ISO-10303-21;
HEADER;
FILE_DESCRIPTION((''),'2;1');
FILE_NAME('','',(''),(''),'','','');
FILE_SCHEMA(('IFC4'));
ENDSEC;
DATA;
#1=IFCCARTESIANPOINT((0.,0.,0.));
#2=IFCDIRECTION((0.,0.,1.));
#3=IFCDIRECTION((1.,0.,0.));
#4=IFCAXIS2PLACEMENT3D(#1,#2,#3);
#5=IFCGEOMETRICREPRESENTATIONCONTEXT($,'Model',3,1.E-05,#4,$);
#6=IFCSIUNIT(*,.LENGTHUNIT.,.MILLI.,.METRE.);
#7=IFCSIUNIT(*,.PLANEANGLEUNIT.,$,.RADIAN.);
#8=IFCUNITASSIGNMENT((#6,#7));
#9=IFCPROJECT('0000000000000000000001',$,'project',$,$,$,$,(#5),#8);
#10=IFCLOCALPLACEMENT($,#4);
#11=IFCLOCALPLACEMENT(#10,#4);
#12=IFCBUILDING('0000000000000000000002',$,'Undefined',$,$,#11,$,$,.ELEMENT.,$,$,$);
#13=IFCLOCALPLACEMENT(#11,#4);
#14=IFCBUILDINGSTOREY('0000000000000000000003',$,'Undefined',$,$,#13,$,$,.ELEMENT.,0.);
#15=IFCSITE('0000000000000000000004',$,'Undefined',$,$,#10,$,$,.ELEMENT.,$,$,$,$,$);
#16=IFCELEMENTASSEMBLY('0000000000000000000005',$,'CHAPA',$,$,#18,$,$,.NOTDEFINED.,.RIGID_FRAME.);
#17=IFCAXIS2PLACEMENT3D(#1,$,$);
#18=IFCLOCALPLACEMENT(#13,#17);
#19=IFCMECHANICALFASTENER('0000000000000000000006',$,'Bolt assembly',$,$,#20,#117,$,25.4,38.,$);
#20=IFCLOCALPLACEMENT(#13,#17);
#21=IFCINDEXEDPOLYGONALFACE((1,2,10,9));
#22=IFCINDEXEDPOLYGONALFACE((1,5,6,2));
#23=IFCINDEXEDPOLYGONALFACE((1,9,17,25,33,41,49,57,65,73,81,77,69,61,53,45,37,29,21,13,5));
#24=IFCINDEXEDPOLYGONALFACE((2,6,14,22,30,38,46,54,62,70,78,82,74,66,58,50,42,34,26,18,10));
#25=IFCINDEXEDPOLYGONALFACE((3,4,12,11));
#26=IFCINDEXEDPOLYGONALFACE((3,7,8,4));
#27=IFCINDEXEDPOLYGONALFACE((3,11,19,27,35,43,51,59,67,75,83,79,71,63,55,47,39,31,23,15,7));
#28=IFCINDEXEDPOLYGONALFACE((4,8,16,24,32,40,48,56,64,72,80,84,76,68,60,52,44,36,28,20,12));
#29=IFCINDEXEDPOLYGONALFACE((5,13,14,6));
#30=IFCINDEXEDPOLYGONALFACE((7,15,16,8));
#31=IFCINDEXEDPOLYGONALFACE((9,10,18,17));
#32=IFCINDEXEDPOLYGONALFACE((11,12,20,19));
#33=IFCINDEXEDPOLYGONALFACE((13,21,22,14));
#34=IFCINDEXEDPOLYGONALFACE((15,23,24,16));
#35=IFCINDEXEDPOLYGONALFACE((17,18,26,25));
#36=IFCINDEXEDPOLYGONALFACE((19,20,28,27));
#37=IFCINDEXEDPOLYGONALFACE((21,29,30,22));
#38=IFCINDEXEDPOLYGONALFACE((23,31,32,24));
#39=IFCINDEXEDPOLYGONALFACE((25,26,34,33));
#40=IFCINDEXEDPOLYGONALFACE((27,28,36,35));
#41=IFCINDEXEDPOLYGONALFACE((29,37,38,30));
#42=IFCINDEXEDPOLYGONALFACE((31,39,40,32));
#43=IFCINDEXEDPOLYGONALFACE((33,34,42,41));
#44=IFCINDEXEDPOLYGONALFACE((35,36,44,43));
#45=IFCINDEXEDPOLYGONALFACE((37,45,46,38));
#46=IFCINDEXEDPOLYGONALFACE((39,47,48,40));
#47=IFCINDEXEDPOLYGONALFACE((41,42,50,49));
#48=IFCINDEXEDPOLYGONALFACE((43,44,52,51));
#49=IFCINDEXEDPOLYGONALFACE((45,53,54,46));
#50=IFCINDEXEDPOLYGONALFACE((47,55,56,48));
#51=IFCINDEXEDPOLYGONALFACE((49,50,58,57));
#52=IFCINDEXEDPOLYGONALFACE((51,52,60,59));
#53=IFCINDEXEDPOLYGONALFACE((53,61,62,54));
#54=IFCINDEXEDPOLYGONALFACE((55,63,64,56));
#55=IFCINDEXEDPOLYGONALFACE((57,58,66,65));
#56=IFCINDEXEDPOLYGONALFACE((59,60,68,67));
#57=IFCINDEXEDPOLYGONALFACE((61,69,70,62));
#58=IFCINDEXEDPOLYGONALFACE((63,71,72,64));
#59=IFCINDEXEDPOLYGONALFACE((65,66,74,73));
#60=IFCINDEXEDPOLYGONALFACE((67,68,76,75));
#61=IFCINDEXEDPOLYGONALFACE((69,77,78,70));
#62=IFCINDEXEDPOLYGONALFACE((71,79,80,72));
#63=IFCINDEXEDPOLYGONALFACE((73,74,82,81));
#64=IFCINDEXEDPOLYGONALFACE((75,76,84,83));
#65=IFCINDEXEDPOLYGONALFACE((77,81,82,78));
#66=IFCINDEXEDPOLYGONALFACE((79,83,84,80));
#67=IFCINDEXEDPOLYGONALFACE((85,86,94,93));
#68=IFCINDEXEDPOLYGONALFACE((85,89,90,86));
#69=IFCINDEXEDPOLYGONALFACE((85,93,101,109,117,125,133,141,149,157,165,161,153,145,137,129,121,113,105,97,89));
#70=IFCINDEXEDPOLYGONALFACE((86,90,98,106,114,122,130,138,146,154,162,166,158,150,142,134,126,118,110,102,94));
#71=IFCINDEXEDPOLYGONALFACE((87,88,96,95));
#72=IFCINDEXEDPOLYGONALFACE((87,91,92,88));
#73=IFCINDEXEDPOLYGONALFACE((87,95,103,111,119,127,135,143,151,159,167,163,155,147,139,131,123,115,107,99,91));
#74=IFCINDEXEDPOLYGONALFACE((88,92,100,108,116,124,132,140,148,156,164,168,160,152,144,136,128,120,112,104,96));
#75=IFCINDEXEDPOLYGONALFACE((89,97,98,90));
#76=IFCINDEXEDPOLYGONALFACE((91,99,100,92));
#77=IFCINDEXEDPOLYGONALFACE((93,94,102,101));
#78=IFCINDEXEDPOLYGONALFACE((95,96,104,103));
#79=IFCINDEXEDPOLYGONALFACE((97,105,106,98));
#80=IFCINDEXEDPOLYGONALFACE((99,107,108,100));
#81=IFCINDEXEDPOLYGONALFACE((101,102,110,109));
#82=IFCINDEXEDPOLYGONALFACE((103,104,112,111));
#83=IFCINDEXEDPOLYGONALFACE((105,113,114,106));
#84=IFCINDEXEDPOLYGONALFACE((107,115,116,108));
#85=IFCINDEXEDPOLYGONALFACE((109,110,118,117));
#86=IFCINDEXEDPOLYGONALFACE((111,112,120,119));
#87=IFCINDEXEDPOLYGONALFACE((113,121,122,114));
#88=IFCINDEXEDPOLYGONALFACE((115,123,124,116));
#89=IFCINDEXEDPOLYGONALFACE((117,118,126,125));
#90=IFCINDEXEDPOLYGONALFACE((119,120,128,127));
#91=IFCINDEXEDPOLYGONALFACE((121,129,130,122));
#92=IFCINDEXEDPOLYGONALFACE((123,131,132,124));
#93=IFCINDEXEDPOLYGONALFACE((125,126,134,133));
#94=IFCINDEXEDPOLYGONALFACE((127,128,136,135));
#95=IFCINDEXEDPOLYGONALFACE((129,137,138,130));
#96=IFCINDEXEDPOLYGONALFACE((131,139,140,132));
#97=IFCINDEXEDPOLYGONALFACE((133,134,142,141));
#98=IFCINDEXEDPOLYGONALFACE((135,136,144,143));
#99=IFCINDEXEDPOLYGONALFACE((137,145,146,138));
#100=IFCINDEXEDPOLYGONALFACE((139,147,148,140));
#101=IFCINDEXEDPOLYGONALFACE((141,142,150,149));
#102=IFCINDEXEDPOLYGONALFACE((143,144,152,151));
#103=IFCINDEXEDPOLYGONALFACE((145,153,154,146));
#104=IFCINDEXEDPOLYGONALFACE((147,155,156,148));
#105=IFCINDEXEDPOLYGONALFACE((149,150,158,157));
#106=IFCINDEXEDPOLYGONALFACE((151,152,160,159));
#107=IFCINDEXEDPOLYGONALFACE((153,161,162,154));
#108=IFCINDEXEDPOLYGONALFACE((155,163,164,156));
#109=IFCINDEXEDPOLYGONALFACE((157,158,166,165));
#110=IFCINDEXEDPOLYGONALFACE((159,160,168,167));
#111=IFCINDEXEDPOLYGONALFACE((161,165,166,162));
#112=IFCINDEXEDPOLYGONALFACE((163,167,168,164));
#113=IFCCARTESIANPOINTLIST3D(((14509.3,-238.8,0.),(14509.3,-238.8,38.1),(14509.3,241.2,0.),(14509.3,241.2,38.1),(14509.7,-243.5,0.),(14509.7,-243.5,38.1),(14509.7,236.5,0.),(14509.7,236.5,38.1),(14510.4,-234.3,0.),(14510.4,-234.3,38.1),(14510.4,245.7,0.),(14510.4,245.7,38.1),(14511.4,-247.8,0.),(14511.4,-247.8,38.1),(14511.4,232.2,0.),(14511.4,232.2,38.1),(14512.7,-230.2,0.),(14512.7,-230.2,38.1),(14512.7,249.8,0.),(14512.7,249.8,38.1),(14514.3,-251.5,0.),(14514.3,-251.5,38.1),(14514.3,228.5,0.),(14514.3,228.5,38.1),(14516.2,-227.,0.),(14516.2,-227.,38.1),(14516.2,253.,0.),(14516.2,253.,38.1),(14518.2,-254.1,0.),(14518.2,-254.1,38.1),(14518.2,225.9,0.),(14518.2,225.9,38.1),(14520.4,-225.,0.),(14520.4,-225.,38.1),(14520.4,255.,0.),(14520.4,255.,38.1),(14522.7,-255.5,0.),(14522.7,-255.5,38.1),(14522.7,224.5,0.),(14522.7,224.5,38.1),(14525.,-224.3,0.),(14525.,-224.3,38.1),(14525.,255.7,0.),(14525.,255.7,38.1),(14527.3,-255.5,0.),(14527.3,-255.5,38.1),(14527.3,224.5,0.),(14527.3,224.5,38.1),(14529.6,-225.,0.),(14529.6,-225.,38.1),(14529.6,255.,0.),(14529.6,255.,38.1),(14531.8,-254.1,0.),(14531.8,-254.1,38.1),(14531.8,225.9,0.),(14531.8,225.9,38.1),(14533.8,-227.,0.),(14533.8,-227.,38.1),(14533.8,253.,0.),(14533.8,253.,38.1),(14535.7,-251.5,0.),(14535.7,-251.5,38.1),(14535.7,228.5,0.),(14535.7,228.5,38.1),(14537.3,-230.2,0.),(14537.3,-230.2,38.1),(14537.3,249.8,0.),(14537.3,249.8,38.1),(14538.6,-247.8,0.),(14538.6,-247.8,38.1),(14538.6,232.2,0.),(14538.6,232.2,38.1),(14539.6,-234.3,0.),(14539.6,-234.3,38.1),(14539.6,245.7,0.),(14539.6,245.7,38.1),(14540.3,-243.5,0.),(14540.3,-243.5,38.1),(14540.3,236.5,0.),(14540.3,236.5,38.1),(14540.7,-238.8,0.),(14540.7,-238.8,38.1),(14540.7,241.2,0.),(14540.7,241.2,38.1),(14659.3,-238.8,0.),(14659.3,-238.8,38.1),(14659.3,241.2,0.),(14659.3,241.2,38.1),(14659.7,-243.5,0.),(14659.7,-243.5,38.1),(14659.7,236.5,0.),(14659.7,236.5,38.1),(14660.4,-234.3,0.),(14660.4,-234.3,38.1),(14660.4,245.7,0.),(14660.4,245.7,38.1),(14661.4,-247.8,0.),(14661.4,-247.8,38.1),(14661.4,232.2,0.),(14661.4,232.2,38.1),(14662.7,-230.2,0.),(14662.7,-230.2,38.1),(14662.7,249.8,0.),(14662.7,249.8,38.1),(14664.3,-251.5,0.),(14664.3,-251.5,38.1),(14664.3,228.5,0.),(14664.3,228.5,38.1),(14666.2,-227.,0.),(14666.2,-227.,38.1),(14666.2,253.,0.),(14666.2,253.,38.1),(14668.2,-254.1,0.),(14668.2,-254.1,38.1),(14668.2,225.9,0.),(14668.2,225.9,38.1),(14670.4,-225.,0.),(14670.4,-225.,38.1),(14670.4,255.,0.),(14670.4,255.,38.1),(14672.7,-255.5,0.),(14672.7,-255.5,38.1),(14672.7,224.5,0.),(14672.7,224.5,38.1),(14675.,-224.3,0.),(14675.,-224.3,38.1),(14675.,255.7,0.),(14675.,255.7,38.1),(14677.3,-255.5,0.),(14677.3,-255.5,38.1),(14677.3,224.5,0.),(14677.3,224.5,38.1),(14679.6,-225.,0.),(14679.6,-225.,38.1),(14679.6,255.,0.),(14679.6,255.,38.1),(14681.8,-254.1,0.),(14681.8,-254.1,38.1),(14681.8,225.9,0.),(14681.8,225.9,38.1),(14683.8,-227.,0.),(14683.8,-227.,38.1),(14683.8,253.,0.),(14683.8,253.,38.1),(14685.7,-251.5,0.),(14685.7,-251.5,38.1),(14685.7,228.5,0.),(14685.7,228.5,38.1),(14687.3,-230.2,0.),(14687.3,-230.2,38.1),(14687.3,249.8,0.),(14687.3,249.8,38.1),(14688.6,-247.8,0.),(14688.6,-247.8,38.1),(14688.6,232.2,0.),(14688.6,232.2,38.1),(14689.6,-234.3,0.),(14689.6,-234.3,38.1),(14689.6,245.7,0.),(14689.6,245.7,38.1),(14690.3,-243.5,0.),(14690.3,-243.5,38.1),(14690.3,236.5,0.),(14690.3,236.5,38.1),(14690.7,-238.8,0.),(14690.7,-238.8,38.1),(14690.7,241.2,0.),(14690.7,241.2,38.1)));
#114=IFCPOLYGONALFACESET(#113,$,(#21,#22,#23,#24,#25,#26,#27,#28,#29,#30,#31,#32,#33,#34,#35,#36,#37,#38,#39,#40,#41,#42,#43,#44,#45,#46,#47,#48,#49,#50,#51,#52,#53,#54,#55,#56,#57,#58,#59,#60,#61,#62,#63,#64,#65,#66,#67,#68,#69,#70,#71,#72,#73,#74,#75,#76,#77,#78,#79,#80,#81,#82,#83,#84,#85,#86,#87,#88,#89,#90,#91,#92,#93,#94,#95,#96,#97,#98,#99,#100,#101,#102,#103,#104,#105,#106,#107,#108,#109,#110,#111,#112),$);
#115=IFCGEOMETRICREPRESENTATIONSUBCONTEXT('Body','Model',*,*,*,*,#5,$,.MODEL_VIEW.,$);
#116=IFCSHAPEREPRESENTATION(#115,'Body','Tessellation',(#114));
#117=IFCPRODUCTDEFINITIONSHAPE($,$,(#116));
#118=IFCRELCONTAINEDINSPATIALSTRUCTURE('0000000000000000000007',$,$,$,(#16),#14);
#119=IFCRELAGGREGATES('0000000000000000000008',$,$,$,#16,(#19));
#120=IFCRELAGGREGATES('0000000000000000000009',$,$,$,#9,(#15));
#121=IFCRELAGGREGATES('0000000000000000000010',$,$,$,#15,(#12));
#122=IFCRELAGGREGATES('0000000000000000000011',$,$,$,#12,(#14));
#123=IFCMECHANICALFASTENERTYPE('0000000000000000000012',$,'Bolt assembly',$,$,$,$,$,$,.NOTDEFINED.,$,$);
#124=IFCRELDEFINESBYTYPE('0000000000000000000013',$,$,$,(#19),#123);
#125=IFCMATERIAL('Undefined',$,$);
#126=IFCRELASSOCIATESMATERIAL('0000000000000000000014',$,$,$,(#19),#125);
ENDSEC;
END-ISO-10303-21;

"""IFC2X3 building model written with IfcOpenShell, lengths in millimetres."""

from ifc_helpers import new_model, si_unit, frame, origin_with_axes, origin_2d_with_axis, place, context, subcontext, project, spatial, circle, extrude, source, transform, mapped, material, type_object, element, aggregate, save


model = new_model("IFC2X3")

# Units and contexts
model_context = context("Model", 3, precision=1e-05, world=origin_with_axes())
body_context = subcontext(model_context, "Body", "Model", "MODEL_VIEW")
ifc_project = project(units=[si_unit("LENGTHUNIT", "METRE", prefix="MILLI"), si_unit("PLANEANGLEUNIT", "RADIAN")], contexts=[model_context])

# Site, building, storey
site_placement = place(None, origin_with_axes())
site = spatial("IfcSite", under=ifc_project, at=site_placement, Name="Undefined", CompositionType="ELEMENT")
building_placement = place(site_placement, origin_with_axes())
building = spatial("IfcBuilding", under=site, at=building_placement, Name="Undefined", CompositionType="ELEMENT")
storey_placement = place(building_placement, origin_with_axes())
storey = spatial("IfcBuildingStorey", under=building, at=storey_placement, Name="Undefined", CompositionType="ELEMENT", Elevation=0.0)

# Element assembly
assembly_1_placement = place(storey_placement, origin_with_axes())
assembly_1 = element("IfcElementAssembly", 1, at=assembly_1_placement, inside=storey, Name="CHAPA", AssemblyPlace="NOTDEFINED", PredefinedType="RIGID_FRAME")

# Shared definitions
ifc_material_1 = material(Name="Undefined")
mechanical_fastener_type = type_object("IfcMechanicalFastenerType", Name="Bolt assembly")

# Mechanical fastener
shared_shape_1 = source(origin_with_axes(), body_context, "Body", "SweptSolid", [
    extrude(circle(Radius=15.7, at=origin_2d_with_axis()), frame((0.0, -38.0, 0.0), z_axis=(0.0, 1.0, 0.0), x_axis=(1.0, 0.0, 0.0)), (0.0, 0.0, 1.0), 38.1),
])
mechanical_fastener_1_placement = place(assembly_1_placement, frame((14600.0, -240.0, 38.0), z_axis=(1.0, 0.0, 0.0), x_axis=(0.0, 1.0, 0.0)))
mechanical_fastener_1 = element("IfcMechanicalFastener", 2, at=mechanical_fastener_1_placement, type_object=mechanical_fastener_type, material=ifc_material_1, Name="Bolt assembly", NominalDiameter=25.4, NominalLength=38.0, context=body_context, shape_type="MappedRepresentation", body=[
    mapped(shared_shape_1, transform((0.0, 0.0, -75.0))),
    mapped(shared_shape_1, transform((0.0, 0.0, 75.0))),
    mapped(shared_shape_1, transform((480.0, 0.0, -75.0))),
    mapped(shared_shape_1, transform((480.0, 0.0, 75.0))),
])
aggregate(assembly_1, [mechanical_fastener_1])

save(model, "model.ifc")
